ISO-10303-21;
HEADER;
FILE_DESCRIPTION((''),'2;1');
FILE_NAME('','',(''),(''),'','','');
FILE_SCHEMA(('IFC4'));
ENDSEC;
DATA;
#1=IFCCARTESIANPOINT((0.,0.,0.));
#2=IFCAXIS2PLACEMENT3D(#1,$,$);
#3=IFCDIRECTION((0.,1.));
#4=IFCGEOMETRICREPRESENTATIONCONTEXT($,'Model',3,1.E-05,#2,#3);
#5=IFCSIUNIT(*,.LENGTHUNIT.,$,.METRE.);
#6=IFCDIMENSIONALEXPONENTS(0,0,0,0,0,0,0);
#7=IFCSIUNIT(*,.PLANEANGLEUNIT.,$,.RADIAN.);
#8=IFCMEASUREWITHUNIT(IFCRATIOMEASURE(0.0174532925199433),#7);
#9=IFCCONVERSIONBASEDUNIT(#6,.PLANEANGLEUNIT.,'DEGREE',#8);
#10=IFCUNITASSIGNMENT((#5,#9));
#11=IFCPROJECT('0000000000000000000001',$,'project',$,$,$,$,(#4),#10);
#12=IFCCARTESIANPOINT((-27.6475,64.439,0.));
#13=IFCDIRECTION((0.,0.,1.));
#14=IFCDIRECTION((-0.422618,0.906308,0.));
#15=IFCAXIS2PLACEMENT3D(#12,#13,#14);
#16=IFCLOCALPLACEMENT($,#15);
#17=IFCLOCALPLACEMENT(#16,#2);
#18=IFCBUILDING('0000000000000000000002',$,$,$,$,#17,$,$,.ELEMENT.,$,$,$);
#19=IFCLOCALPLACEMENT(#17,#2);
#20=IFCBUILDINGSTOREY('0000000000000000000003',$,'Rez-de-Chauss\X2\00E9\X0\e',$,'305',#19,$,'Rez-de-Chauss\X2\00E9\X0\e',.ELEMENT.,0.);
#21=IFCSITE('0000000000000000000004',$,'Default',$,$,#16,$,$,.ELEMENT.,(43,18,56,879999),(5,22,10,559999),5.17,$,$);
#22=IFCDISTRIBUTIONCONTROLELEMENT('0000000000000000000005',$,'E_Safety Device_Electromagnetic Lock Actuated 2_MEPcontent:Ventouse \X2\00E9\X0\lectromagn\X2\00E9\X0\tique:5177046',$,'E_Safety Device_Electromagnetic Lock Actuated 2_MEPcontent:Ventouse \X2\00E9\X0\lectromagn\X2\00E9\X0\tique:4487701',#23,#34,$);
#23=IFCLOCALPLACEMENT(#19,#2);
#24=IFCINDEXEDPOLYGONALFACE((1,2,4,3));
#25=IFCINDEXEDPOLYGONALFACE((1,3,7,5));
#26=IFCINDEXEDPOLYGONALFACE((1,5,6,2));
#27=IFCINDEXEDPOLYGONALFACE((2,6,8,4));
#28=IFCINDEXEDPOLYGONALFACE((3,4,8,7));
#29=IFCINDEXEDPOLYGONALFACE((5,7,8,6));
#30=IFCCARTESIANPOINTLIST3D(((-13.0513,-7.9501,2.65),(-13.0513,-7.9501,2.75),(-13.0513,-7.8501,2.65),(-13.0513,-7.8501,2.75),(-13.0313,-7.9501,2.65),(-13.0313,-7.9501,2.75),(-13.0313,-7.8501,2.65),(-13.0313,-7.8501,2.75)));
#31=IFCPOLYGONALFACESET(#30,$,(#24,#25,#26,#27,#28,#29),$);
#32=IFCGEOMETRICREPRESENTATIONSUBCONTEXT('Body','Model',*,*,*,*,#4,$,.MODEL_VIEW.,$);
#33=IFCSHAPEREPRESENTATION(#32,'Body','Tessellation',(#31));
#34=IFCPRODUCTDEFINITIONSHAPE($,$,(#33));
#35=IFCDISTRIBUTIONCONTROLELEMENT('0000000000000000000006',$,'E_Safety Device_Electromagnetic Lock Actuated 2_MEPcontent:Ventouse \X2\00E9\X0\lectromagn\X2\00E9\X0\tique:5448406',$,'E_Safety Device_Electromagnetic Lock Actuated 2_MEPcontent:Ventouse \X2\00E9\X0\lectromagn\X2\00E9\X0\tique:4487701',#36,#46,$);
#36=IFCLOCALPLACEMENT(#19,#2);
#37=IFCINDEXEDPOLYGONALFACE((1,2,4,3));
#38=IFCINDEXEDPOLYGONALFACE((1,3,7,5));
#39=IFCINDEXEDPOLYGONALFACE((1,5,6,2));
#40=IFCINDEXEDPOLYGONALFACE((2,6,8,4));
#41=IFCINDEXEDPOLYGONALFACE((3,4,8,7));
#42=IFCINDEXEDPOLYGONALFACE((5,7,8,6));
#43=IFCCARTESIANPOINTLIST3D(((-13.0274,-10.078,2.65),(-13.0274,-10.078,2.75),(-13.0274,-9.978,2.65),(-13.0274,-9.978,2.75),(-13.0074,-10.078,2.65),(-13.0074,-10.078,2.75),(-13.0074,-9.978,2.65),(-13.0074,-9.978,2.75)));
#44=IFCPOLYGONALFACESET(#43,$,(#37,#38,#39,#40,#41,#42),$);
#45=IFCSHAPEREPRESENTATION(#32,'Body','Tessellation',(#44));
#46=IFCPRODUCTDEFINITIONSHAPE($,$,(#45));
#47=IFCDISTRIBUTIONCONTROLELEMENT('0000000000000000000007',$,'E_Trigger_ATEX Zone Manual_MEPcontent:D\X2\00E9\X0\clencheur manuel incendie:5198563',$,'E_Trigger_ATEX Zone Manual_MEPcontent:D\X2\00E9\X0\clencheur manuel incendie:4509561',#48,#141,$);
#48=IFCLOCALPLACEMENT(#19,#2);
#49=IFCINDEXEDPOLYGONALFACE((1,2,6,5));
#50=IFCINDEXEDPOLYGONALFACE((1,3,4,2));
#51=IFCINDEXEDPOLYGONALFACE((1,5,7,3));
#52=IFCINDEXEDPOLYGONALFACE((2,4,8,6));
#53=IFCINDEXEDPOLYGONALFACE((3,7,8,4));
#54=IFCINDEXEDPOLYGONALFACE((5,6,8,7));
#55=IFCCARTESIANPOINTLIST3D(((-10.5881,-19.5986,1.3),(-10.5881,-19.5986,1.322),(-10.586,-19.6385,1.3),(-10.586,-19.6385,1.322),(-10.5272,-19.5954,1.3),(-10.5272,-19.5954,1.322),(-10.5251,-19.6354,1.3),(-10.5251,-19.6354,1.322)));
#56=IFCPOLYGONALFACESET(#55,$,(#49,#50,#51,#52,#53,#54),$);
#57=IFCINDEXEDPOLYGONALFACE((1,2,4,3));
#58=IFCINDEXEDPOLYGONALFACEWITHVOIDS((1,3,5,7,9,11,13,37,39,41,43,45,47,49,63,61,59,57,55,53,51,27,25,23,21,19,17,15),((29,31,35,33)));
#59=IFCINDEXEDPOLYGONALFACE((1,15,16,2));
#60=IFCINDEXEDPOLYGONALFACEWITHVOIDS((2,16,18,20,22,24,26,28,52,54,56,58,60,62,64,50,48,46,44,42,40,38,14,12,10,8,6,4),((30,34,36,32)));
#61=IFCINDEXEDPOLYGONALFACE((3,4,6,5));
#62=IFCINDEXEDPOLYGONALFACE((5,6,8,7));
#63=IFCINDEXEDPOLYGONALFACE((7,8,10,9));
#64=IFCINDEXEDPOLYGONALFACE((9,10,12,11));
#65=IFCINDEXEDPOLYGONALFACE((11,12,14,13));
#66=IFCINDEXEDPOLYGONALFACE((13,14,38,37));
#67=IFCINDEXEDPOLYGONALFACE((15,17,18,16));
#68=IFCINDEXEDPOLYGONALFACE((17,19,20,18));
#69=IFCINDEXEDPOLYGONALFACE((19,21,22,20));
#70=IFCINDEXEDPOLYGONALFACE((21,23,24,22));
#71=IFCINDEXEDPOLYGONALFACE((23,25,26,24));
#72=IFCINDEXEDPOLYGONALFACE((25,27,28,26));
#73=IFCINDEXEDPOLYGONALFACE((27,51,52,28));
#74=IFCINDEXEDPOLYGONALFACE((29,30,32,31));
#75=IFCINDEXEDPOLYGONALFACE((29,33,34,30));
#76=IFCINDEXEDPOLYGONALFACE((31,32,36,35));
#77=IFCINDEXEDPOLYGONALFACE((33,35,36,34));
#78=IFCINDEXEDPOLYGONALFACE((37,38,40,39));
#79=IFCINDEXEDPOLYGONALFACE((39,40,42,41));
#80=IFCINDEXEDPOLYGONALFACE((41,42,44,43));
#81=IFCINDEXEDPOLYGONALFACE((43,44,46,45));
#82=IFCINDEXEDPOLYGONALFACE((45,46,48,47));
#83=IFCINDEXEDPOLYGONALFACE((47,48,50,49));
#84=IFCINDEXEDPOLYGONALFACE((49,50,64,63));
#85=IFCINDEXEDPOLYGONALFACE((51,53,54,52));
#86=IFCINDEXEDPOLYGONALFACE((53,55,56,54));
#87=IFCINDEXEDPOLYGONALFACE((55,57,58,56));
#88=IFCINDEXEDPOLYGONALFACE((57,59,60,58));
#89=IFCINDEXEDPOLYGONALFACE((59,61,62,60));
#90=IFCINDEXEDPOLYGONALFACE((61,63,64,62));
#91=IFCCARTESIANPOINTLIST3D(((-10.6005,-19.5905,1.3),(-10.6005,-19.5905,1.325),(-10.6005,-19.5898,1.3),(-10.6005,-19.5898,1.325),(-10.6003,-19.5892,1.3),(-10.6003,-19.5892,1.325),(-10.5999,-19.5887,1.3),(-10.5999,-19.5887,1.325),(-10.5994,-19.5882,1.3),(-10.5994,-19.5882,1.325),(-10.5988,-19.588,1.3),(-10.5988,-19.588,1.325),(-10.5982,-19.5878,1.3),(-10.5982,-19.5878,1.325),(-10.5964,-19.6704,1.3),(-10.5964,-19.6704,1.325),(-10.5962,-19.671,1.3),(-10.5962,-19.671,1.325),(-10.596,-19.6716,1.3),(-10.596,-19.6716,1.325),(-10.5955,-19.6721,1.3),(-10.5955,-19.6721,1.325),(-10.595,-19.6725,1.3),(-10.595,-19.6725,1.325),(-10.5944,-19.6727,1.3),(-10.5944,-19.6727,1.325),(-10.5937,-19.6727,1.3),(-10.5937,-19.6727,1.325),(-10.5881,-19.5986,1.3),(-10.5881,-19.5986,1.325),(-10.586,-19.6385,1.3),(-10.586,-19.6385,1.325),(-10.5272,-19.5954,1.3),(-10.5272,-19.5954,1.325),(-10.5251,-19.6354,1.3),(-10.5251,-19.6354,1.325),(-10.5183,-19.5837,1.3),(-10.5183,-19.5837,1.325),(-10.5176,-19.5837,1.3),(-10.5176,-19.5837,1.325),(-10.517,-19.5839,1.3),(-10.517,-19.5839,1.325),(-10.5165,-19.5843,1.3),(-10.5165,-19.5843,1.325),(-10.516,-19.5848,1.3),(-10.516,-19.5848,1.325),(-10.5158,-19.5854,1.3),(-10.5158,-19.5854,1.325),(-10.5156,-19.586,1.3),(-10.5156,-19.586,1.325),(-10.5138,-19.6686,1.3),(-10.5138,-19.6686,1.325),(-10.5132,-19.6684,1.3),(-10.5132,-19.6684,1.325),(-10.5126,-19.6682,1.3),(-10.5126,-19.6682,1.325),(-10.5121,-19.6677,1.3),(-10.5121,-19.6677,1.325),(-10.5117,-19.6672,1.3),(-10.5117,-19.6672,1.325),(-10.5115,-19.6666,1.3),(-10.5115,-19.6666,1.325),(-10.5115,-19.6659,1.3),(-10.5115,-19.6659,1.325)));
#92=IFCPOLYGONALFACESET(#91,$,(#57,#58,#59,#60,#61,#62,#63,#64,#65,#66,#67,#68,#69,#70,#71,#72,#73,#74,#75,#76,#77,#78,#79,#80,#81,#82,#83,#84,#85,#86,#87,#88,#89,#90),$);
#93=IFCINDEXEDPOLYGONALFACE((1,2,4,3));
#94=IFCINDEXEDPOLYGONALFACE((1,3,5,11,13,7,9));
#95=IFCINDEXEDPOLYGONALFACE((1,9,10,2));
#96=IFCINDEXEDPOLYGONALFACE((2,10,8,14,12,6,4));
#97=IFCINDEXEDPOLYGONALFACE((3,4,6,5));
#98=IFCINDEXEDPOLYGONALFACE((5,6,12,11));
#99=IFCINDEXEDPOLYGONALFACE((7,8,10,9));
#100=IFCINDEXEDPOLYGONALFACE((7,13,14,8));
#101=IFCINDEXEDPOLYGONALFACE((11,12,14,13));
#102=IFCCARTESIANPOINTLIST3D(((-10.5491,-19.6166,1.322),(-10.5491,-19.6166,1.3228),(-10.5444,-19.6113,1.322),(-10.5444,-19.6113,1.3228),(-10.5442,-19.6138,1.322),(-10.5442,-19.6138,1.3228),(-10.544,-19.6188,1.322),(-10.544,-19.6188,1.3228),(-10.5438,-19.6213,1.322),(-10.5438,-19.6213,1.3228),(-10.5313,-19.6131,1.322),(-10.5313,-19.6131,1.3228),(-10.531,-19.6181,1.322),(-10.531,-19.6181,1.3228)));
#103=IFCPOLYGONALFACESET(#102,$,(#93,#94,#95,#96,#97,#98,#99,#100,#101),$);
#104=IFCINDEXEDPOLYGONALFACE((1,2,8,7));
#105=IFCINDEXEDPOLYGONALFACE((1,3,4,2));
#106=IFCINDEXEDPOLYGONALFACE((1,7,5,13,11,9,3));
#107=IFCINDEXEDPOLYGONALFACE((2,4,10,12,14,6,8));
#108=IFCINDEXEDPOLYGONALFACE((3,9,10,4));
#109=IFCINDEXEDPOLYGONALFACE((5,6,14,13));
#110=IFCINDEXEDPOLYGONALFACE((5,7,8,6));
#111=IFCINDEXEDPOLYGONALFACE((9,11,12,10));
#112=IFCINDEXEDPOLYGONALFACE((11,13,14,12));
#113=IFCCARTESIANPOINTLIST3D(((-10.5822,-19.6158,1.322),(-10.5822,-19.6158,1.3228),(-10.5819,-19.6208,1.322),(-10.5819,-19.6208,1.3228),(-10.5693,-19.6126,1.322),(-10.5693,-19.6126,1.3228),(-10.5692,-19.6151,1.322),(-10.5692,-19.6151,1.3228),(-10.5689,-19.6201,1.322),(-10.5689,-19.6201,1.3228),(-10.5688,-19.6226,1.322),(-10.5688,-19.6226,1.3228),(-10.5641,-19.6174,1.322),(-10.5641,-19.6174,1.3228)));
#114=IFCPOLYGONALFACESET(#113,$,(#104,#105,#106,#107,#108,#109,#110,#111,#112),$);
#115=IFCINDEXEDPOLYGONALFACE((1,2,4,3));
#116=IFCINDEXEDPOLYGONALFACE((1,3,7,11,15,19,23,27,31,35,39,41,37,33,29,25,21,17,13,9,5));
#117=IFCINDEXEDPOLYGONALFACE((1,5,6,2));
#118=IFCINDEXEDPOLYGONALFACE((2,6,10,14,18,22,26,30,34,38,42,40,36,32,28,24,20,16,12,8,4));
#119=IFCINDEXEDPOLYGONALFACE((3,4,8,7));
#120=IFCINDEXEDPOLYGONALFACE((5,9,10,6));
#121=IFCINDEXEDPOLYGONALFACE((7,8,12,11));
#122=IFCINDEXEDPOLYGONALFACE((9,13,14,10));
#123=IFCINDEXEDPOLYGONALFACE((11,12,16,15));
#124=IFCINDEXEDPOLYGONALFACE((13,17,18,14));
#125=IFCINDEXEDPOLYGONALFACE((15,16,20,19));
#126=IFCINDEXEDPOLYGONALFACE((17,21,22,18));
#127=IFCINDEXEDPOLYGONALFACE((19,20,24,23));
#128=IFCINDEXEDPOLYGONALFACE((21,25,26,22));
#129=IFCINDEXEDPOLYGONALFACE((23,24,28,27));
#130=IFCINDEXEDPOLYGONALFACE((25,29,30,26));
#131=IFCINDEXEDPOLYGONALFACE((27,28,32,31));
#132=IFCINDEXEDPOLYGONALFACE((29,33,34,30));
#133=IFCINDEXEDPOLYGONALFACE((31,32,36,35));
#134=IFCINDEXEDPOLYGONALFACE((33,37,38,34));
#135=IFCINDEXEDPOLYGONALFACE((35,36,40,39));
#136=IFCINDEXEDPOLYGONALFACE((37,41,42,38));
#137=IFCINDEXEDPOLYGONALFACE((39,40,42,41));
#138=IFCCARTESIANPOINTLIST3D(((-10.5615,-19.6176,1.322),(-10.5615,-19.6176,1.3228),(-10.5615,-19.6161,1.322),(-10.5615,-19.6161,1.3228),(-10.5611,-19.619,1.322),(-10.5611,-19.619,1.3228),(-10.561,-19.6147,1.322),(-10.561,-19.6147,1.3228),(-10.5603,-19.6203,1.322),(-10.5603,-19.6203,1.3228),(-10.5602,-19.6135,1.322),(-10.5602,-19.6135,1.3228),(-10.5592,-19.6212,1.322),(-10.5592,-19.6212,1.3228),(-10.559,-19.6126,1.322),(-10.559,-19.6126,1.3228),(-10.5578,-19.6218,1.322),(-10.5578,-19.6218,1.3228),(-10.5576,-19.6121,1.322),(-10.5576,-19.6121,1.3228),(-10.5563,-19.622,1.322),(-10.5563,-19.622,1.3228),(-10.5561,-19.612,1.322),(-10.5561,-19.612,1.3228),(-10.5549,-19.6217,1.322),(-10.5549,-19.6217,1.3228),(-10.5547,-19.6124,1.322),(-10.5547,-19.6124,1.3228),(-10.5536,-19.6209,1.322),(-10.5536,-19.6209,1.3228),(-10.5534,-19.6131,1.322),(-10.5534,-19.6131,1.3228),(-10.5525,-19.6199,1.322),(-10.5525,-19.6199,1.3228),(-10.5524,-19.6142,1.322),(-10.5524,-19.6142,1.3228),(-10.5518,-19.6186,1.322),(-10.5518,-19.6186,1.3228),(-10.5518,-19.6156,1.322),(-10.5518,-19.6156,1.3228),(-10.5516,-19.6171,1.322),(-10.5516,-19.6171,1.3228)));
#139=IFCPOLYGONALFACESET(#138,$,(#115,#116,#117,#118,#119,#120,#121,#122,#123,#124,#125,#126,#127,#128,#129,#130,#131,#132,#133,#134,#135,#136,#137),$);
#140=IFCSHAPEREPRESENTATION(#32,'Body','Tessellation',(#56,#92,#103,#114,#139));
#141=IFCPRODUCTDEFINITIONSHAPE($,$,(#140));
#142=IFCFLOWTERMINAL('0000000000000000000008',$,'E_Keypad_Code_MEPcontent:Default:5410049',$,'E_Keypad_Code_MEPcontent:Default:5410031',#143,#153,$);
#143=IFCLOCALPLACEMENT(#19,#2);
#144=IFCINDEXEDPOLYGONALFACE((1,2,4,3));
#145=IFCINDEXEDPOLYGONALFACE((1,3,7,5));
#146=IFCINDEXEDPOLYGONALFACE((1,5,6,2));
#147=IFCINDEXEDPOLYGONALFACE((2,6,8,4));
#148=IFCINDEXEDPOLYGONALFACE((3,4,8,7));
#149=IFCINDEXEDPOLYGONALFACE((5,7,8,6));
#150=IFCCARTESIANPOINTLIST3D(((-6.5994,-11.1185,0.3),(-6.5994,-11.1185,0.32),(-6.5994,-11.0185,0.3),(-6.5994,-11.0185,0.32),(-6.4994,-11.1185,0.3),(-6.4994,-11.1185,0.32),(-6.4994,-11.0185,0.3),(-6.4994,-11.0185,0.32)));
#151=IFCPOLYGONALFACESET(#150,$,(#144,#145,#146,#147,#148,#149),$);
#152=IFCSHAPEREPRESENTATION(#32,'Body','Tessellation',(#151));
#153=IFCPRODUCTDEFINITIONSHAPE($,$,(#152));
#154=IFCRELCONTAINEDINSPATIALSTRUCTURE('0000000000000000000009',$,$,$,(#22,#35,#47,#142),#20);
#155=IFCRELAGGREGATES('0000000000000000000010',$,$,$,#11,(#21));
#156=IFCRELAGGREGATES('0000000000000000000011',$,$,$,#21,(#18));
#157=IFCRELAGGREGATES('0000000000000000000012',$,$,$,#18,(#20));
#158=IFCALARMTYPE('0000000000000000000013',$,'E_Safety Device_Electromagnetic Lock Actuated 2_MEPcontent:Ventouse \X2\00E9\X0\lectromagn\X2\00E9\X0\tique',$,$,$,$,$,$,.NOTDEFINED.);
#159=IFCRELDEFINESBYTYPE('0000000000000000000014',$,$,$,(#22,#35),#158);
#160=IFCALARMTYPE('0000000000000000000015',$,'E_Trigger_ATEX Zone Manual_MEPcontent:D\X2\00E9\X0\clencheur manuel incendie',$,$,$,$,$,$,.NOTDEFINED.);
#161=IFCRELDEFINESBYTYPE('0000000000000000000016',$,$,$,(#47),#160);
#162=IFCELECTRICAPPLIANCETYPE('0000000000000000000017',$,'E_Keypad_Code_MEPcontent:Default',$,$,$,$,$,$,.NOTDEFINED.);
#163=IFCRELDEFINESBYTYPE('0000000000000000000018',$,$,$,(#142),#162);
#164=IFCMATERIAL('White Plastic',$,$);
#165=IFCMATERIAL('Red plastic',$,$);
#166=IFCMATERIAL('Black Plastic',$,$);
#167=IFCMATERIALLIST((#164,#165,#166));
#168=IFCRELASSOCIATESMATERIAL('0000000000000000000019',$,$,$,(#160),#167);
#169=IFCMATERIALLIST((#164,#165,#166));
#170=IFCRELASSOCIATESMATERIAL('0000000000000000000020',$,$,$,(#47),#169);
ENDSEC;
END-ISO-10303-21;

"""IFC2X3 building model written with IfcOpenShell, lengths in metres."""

from ifc_helpers import new_model, entity, si_unit, converted_unit, direction, frame, frame_2d, origin, origin_2d_with_axis, place, context, subcontext, project, spatial, polyline, circle_curve, parameter, trimmed, segment, composite_curve, rectangle, circle, outline, extrude, source, transform, mapped, material, material_list, type_object, type_shapes, element, save


model = new_model("IFC2X3")

# Units and contexts
model_context = context("Model", 3, precision=1e-05, world=origin(), true_north=direction((0.0, 1.0)))
body_context = subcontext(model_context, "Body", "Model", "MODEL_VIEW")
ifc_project = project(units=[si_unit("LENGTHUNIT", "METRE"), converted_unit("PLANEANGLEUNIT", "DEGREE", entity("IfcRatioMeasure", 0.0174532925199433), si_unit("PLANEANGLEUNIT", "RADIAN"), dimensions=[0, 0, 0, 0, 0, 0, 0])], contexts=[model_context])

# Site, building, storey
site_placement = place(None, frame((-27.6475, 64.439, 0.0), z_axis=(0.0, 0.0, 1.0), x_axis=(-0.422618, 0.906308, 0.0)))
site = spatial("IfcSite", under=ifc_project, at=site_placement, Name="Default", CompositionType="ELEMENT", RefLatitude=(43, 18, 56, 879999), RefLongitude=(5, 22, 10, 559999), RefElevation=5.17)
building_placement = place(site_placement, origin())
building = spatial("IfcBuilding", under=site, at=building_placement, CompositionType="ELEMENT")
storey_placement = place(building_placement, origin())
storey = spatial("IfcBuildingStorey", under=building, at=storey_placement, Name="Rez-de-Chaussée", ObjectType="305", LongName="Rez-de-Chaussée", CompositionType="ELEMENT", Elevation=0.0)

# Distribution control elements
alarm_type_1 = type_object("IfcAlarmType", Name="E_Safety Device_Electromagnetic Lock Actuated 2_MEPcontent:Ventouse électromagnétique", PredefinedType="NOTDEFINED")
shared_shape_1 = source(origin(), body_context, "Body", "SweptSolid", [
    extrude(rectangle(XDim=0.02, YDim=0.1, at=frame_2d((0.0, 0.0), x_axis=(1.0, 0.0))), frame((0.0, 0.01, -0.05), z_axis=(0.0, 0.0, 1.0), x_axis=(0.0, -1.0, 0.0)), (0.0, 0.0, 1.0), 0.1),
])
type_shapes(alarm_type_1, [shared_shape_1])
for number, where, z_axis, x_axis, name in (
    (1, (-13.0313, -7.9001, 2.7), (0.0, 0.0, 1.0), (0.0, 1.0, 0.0), "E_Safety Device_Electromagnetic Lock Actuated 2_MEPcontent:Ventouse électromagnétique:5177046"),
    (2, (-13.0074, -10.028, 2.7), (0.0, 0.0, 1.0), (0.0, 1.0, 0.0), "E_Safety Device_Electromagnetic Lock Actuated 2_MEPcontent:Ventouse électromagnétique:5448406"),
):
    element("IfcDistributionControlElement", number, at=place(storey_placement, frame(where, z_axis=z_axis, x_axis=x_axis)), inside=storey, type_object=alarm_type_1, Name=name, ObjectType="E_Safety Device_Electromagnetic Lock Actuated 2_MEPcontent:Ventouse électromagnétique:4487701", context=body_context, shape_type="MappedRepresentation", body=[
        mapped(shared_shape_1, transform((0.0, 0.0, 0.0), scale=1.0)),
    ])
ifc_material_1 = material(Name="White Plastic")
ifc_material_2 = material(Name="Red plastic")
ifc_material_3 = material(Name="Black Plastic")
ifc_material_list_1 = material_list([ifc_material_1, ifc_material_2, ifc_material_3])
ifc_material_list_2 = material_list([ifc_material_1, ifc_material_2, ifc_material_3])
alarm_type_2 = type_object("IfcAlarmType", Name="E_Trigger_ATEX Zone Manual_MEPcontent:Déclencheur manuel incendie", PredefinedType="NOTDEFINED", material=ifc_material_list_2)
shared_shape_2 = source(origin(), body_context, "Body", "SweptSolid", [
    extrude(rectangle(XDim=0.061, YDim=0.04, at=origin_2d_with_axis()), frame((0.0, 0.0112, 0.0)), (0.0, 0.0, 1.0), 0.022),
    extrude(outline(composite_curve([segment(polyline([(-0.04, -0.0425), (0.04, -0.0425)]), True, "CONTINUOUS"), segment(trimmed(circle_curve(frame_2d((0.04, -0.04), x_axis=(-1.0, 0.0)), 0.0025), [parameter(90.0)], [parameter(180.0)], True, "PARAMETER"), True, "CONTINUOUS"), segment(polyline([(0.0425, -0.04), (0.0425, 0.04)]), True, "CONTINUOUS"), segment(trimmed(circle_curve(frame_2d((0.04, 0.04), x_axis=(-1.0, 0.0)), 0.0025), [parameter(180.0)], [parameter(270.0)], True, "PARAMETER"), True, "CONTINUOUS"), segment(polyline([(0.04, 0.0425), (-0.04, 0.0425)]), True, "CONTINUOUS"), segment(trimmed(circle_curve(frame_2d((-0.04, 0.04), x_axis=(-1.0, 0.0)), 0.0025), [parameter(270.0)], [parameter(0.0)], True, "PARAMETER"), True, "CONTINUOUS"), segment(polyline([(-0.0425, 0.04), (-0.0425, -0.04)]), True, "CONTINUOUS"), segment(trimmed(circle_curve(frame_2d((-0.04, -0.04), x_axis=(-1.0, 0.0)), 0.0025), [parameter(360.0)], [parameter(90.0)], True, "PARAMETER"), True, "CONTINUOUS")], self_intersect=False), holes=[polyline([(-0.0305, -0.0088), (-0.0305, 0.0312), (0.0305, 0.0312), (0.0305, -0.0088), (-0.0305, -0.0088)])]), origin(), (0.0, 0.0, 1.0), 0.025),
    extrude(outline(polyline([(-0.01, 0.0025), (-0.01, -0.0025), (0.003, -0.0025), (0.003, -0.005), (0.008, 0.0), (0.003, 0.005), (0.003, 0.0025), (-0.01, 0.0025)])), frame((0.0155, 0.0112, 0.022), z_axis=(0.0, 0.0, -1.0), x_axis=(-1.0, 0.0, 0.0)), (0.0, 0.0, -1.0), 0.0008),
    extrude(outline(polyline([(-0.0014, -0.0057), (0.0057, -0.0057), (0.0057, 0.0014), (0.0039, -0.0004), (-0.0053, 0.0088), (-0.0088, 0.0053), (0.0004, -0.0039), (-0.0014, -0.0057)])), frame((-0.0155, 0.0112, 0.022), z_axis=(0.0, 0.0, 1.0), x_axis=(0.707107, 0.707107, 0.0)), (0.0, 0.0, 1.0), 0.0008),
    extrude(circle(Radius=0.005, at=frame_2d((0.0, 0.0), x_axis=(1.0, 0.0))), frame((0.0, 0.0112, 0.022), z_axis=(0.0, 0.0, 1.0), x_axis=(0.0, -1.0, 0.0)), (0.0, 0.0, 1.0), 0.0008),
])
type_shapes(alarm_type_2, [shared_shape_2])
distribution_control_element_1_placement = place(storey_placement, frame((-10.556, -19.6282, 1.3), z_axis=(0.0, 0.0, 1.0), x_axis=(0.998641, 0.05212, 0.0)))
element("IfcDistributionControlElement", 3, at=distribution_control_element_1_placement, inside=storey, type_object=alarm_type_2, material=ifc_material_list_1, Name="E_Trigger_ATEX Zone Manual_MEPcontent:Déclencheur manuel incendie:5198563", ObjectType="E_Trigger_ATEX Zone Manual_MEPcontent:Déclencheur manuel incendie:4509561", context=body_context, shape_type="MappedRepresentation", body=[
    mapped(shared_shape_2, transform((0.0, 0.0, 0.0), scale=1.0)),
])

# Flow terminal
electric_appliance_type_1 = type_object("IfcElectricApplianceType", Name="E_Keypad_Code_MEPcontent:Default", PredefinedType="NOTDEFINED")
shared_shape_3 = source(origin(), body_context, "Body", "SweptSolid", [
    extrude(rectangle(XDim=0.1, YDim=0.1, at=origin_2d_with_axis()), frame((0.0, 0.0, 0.0), z_axis=(0.0, 0.0, 1.0), x_axis=(0.0, -1.0, 0.0)), (0.0, 0.0, 1.0), 0.02),
])
type_shapes(electric_appliance_type_1, [shared_shape_3])
flow_terminal_1_placement = place(storey_placement, frame((-6.5494, -11.0685, 0.3), z_axis=(0.0, 0.0, 1.0), x_axis=(0.0, -1.0, 0.0)))
element("IfcFlowTerminal", 4, at=flow_terminal_1_placement, inside=storey, type_object=electric_appliance_type_1, Name="E_Keypad_Code_MEPcontent:Default:5410049", ObjectType="E_Keypad_Code_MEPcontent:Default:5410031", context=body_context, shape_type="MappedRepresentation", body=[
    mapped(shared_shape_3, transform((0.0, 0.0, 0.0), scale=1.0)),
])

save(model, "model.ifc")
